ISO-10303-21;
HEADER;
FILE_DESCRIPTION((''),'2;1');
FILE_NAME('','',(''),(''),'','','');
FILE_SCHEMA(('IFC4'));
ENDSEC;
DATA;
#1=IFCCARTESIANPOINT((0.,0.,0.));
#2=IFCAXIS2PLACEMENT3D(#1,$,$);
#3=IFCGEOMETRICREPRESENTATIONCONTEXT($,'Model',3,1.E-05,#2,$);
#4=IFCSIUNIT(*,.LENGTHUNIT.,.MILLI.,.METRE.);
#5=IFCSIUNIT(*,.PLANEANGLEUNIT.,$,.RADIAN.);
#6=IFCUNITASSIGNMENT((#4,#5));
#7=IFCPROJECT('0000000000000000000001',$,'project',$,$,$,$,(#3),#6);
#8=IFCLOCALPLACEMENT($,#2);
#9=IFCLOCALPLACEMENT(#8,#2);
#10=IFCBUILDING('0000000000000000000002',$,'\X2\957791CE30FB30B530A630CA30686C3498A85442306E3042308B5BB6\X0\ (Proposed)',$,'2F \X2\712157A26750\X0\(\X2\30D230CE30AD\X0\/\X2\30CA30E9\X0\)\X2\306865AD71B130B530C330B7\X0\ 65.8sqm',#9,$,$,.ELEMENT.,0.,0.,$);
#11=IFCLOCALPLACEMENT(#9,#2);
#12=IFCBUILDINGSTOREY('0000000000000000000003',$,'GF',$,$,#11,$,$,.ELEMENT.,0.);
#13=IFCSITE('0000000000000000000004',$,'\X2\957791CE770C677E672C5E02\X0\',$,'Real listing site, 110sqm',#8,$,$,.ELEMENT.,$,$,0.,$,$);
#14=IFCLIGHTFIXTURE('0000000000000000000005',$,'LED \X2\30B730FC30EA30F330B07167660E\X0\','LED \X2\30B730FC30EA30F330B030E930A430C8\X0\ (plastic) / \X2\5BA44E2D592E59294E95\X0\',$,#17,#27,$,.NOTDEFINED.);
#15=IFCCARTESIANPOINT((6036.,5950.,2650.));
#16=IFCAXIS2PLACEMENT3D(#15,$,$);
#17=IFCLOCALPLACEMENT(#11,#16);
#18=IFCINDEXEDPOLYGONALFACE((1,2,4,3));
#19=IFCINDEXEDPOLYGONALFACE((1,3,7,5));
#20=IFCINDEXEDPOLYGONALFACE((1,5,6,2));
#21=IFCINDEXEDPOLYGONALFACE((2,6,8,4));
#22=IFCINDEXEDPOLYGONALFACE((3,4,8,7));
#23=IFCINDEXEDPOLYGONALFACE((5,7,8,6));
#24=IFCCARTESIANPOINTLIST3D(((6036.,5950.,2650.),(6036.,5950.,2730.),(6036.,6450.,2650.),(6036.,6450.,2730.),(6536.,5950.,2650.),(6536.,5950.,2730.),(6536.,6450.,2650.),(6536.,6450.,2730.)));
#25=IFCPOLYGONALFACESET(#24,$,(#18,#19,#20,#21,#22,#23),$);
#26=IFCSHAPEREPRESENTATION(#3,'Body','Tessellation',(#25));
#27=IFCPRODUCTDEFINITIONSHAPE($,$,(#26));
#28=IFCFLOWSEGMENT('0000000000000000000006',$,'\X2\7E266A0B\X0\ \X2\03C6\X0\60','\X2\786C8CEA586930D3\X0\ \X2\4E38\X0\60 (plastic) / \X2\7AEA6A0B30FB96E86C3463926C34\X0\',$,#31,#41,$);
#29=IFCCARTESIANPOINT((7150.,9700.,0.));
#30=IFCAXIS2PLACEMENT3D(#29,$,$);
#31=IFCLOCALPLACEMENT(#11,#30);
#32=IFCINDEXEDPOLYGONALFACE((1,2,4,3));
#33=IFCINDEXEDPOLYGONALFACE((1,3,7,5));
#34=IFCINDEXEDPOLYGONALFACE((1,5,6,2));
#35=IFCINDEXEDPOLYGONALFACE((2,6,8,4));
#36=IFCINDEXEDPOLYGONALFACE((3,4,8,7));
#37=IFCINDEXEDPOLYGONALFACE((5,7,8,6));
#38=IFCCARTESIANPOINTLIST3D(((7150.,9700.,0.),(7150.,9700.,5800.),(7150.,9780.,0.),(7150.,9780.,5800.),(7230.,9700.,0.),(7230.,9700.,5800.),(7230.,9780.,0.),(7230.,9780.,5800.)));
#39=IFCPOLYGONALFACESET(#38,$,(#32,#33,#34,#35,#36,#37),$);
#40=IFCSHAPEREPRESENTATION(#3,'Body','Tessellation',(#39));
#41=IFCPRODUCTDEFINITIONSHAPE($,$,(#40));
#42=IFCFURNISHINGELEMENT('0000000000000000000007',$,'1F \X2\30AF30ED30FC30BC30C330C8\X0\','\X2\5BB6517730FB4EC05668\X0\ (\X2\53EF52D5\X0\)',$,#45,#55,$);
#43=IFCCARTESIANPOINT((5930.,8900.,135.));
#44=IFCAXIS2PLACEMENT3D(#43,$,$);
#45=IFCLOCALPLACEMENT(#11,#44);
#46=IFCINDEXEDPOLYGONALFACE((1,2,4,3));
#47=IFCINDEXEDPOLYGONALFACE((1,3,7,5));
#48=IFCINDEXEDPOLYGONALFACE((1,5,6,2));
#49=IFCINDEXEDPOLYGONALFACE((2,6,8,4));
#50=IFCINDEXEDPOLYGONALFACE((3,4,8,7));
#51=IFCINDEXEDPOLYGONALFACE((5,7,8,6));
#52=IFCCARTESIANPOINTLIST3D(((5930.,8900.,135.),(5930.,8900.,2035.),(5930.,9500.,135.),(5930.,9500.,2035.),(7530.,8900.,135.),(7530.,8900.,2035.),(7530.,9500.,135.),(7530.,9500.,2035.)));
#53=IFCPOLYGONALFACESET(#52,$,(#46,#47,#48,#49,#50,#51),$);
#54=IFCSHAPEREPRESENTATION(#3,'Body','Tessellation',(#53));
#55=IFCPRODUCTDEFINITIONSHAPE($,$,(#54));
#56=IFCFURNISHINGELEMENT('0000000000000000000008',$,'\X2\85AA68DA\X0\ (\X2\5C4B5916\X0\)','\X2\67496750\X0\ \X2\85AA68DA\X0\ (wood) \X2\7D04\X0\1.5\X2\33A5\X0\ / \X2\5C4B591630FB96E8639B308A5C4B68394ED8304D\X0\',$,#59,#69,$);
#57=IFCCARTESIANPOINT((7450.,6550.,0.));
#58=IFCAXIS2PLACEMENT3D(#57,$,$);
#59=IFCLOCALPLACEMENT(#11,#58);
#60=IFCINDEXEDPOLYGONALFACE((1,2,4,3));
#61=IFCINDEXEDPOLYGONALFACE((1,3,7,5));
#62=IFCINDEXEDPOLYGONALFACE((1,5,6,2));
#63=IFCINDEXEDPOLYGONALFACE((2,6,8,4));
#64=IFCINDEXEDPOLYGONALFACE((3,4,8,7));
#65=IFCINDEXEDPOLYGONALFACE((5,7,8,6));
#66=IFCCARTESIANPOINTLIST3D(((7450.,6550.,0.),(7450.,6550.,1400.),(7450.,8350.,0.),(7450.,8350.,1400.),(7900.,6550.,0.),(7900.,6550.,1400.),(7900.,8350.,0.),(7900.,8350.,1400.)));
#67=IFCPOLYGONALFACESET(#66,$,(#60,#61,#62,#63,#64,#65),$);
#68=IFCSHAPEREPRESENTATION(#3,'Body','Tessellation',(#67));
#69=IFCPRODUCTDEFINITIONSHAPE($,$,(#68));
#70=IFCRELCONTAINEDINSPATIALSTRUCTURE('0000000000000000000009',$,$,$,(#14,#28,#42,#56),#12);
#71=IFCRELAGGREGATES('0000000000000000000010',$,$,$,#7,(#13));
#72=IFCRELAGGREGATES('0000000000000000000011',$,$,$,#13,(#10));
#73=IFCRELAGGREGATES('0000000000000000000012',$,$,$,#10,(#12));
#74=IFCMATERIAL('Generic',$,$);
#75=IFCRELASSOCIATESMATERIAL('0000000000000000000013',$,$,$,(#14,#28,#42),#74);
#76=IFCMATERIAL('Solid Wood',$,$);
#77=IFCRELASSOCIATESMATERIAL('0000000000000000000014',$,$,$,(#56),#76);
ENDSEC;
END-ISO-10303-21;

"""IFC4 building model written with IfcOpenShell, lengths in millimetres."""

from ifc_helpers import new_model, si_unit, frame, frame_2d, origin, place, context, project, spatial, rectangle, extrude, material, element, save


model = new_model("IFC4")

# Units and contexts
model_context = context("Model", 3, precision=1e-05, world=origin())
ifc_project = project(units=[si_unit("LENGTHUNIT", "METRE", prefix="MILLI"), si_unit("PLANEANGLEUNIT", "RADIAN")], contexts=[model_context])

# Site, building, storey
site_placement = place(None, origin())
site = spatial("IfcSite", under=ifc_project, at=site_placement, Name="長野県松本市", ObjectType="Real listing site, 110sqm", CompositionType="ELEMENT", RefElevation=0.0)
building_placement = place(site_placement, origin())
building = spatial("IfcBuilding", under=site, at=building_placement, Name="長野・サウナと水風呂のある家 (Proposed)", ObjectType="2F 無垢材(ヒノキ/ナラ)と断熱サッシ 65.8sqm", CompositionType="ELEMENT", ElevationOfRefHeight=0.0, ElevationOfTerrain=0.0)
storey_placement = place(building_placement, origin())
storey = spatial("IfcBuildingStorey", under=building, at=storey_placement, Name="GF", CompositionType="ELEMENT", Elevation=0.0)

# Shared definitions
ifc_material_1 = material(Name="Solid Wood")

# Shared definitions
ifc_material_2 = material(Name="Generic")

# Light fixture
light_fixture_placement = place(storey_placement, frame((6036.0, 5950.0, 2650.0)))
element("IfcLightFixture", 1, at=light_fixture_placement, inside=storey, material=ifc_material_2, Name="LED シーリング照明", Description="LED シーリングライト (plastic) / 室中央天井", PredefinedType="NOTDEFINED", context=model_context, shape_type="SweptSolid", body=[
    extrude(rectangle(XDim=500.0, YDim=500.0, at=frame_2d((250.0, 250.0))), frame((6036.0, 5950.0, 2650.0)), (0.0, 0.0, 1.0), 80.0),
])

# Flow segment
flow_segment_placement = place(storey_placement, frame((7150.0, 9700.0, 0.0)))
element("IfcFlowSegment", 2, at=flow_segment_placement, inside=storey, material=ifc_material_2, Name="縦樋 φ60", Description="硬質塩ビ 丸60 (plastic) / 竪樋・雨水排水", context=model_context, shape_type="SweptSolid", body=[
    extrude(rectangle(XDim=80.0, YDim=80.0, at=frame_2d((40.0, 40.0))), frame((7150.0, 9700.0, 0.0)), (0.0, 0.0, 1.0), 5800.0),
])

# Furnishing elements
furnishing_1_placement = place(storey_placement, frame((5930.0, 8900.0, 135.0)))
element("IfcFurnishingElement", 3, at=furnishing_1_placement, inside=storey, material=ifc_material_2, Name="1F クローゼット", Description="家具・什器 (可動)", context=model_context, shape_type="SweptSolid", body=[
    extrude(rectangle(XDim=1600.0, YDim=600.0, at=frame_2d((800.0, 300.0))), frame((5930.0, 8900.0, 135.0)), (0.0, 0.0, 1.0), 1900.0),
])
furnishing_2_placement = place(storey_placement, frame((7450.0, 6550.0, 0.0)))
element("IfcFurnishingElement", 4, at=furnishing_2_placement, inside=storey, material=ifc_material_1, Name="薪棚 (屋外)", Description="杉材 薪棚 (wood) 約1.5㎥ / 屋外・雨掛り屋根付き", context=model_context, shape_type="SweptSolid", body=[
    extrude(rectangle(XDim=450.0, YDim=1800.0, at=frame_2d((225.0, 900.0))), frame((7450.0, 6550.0, 0.0)), (0.0, 0.0, 1.0), 1400.0),
])

save(model, "model.ifc")
